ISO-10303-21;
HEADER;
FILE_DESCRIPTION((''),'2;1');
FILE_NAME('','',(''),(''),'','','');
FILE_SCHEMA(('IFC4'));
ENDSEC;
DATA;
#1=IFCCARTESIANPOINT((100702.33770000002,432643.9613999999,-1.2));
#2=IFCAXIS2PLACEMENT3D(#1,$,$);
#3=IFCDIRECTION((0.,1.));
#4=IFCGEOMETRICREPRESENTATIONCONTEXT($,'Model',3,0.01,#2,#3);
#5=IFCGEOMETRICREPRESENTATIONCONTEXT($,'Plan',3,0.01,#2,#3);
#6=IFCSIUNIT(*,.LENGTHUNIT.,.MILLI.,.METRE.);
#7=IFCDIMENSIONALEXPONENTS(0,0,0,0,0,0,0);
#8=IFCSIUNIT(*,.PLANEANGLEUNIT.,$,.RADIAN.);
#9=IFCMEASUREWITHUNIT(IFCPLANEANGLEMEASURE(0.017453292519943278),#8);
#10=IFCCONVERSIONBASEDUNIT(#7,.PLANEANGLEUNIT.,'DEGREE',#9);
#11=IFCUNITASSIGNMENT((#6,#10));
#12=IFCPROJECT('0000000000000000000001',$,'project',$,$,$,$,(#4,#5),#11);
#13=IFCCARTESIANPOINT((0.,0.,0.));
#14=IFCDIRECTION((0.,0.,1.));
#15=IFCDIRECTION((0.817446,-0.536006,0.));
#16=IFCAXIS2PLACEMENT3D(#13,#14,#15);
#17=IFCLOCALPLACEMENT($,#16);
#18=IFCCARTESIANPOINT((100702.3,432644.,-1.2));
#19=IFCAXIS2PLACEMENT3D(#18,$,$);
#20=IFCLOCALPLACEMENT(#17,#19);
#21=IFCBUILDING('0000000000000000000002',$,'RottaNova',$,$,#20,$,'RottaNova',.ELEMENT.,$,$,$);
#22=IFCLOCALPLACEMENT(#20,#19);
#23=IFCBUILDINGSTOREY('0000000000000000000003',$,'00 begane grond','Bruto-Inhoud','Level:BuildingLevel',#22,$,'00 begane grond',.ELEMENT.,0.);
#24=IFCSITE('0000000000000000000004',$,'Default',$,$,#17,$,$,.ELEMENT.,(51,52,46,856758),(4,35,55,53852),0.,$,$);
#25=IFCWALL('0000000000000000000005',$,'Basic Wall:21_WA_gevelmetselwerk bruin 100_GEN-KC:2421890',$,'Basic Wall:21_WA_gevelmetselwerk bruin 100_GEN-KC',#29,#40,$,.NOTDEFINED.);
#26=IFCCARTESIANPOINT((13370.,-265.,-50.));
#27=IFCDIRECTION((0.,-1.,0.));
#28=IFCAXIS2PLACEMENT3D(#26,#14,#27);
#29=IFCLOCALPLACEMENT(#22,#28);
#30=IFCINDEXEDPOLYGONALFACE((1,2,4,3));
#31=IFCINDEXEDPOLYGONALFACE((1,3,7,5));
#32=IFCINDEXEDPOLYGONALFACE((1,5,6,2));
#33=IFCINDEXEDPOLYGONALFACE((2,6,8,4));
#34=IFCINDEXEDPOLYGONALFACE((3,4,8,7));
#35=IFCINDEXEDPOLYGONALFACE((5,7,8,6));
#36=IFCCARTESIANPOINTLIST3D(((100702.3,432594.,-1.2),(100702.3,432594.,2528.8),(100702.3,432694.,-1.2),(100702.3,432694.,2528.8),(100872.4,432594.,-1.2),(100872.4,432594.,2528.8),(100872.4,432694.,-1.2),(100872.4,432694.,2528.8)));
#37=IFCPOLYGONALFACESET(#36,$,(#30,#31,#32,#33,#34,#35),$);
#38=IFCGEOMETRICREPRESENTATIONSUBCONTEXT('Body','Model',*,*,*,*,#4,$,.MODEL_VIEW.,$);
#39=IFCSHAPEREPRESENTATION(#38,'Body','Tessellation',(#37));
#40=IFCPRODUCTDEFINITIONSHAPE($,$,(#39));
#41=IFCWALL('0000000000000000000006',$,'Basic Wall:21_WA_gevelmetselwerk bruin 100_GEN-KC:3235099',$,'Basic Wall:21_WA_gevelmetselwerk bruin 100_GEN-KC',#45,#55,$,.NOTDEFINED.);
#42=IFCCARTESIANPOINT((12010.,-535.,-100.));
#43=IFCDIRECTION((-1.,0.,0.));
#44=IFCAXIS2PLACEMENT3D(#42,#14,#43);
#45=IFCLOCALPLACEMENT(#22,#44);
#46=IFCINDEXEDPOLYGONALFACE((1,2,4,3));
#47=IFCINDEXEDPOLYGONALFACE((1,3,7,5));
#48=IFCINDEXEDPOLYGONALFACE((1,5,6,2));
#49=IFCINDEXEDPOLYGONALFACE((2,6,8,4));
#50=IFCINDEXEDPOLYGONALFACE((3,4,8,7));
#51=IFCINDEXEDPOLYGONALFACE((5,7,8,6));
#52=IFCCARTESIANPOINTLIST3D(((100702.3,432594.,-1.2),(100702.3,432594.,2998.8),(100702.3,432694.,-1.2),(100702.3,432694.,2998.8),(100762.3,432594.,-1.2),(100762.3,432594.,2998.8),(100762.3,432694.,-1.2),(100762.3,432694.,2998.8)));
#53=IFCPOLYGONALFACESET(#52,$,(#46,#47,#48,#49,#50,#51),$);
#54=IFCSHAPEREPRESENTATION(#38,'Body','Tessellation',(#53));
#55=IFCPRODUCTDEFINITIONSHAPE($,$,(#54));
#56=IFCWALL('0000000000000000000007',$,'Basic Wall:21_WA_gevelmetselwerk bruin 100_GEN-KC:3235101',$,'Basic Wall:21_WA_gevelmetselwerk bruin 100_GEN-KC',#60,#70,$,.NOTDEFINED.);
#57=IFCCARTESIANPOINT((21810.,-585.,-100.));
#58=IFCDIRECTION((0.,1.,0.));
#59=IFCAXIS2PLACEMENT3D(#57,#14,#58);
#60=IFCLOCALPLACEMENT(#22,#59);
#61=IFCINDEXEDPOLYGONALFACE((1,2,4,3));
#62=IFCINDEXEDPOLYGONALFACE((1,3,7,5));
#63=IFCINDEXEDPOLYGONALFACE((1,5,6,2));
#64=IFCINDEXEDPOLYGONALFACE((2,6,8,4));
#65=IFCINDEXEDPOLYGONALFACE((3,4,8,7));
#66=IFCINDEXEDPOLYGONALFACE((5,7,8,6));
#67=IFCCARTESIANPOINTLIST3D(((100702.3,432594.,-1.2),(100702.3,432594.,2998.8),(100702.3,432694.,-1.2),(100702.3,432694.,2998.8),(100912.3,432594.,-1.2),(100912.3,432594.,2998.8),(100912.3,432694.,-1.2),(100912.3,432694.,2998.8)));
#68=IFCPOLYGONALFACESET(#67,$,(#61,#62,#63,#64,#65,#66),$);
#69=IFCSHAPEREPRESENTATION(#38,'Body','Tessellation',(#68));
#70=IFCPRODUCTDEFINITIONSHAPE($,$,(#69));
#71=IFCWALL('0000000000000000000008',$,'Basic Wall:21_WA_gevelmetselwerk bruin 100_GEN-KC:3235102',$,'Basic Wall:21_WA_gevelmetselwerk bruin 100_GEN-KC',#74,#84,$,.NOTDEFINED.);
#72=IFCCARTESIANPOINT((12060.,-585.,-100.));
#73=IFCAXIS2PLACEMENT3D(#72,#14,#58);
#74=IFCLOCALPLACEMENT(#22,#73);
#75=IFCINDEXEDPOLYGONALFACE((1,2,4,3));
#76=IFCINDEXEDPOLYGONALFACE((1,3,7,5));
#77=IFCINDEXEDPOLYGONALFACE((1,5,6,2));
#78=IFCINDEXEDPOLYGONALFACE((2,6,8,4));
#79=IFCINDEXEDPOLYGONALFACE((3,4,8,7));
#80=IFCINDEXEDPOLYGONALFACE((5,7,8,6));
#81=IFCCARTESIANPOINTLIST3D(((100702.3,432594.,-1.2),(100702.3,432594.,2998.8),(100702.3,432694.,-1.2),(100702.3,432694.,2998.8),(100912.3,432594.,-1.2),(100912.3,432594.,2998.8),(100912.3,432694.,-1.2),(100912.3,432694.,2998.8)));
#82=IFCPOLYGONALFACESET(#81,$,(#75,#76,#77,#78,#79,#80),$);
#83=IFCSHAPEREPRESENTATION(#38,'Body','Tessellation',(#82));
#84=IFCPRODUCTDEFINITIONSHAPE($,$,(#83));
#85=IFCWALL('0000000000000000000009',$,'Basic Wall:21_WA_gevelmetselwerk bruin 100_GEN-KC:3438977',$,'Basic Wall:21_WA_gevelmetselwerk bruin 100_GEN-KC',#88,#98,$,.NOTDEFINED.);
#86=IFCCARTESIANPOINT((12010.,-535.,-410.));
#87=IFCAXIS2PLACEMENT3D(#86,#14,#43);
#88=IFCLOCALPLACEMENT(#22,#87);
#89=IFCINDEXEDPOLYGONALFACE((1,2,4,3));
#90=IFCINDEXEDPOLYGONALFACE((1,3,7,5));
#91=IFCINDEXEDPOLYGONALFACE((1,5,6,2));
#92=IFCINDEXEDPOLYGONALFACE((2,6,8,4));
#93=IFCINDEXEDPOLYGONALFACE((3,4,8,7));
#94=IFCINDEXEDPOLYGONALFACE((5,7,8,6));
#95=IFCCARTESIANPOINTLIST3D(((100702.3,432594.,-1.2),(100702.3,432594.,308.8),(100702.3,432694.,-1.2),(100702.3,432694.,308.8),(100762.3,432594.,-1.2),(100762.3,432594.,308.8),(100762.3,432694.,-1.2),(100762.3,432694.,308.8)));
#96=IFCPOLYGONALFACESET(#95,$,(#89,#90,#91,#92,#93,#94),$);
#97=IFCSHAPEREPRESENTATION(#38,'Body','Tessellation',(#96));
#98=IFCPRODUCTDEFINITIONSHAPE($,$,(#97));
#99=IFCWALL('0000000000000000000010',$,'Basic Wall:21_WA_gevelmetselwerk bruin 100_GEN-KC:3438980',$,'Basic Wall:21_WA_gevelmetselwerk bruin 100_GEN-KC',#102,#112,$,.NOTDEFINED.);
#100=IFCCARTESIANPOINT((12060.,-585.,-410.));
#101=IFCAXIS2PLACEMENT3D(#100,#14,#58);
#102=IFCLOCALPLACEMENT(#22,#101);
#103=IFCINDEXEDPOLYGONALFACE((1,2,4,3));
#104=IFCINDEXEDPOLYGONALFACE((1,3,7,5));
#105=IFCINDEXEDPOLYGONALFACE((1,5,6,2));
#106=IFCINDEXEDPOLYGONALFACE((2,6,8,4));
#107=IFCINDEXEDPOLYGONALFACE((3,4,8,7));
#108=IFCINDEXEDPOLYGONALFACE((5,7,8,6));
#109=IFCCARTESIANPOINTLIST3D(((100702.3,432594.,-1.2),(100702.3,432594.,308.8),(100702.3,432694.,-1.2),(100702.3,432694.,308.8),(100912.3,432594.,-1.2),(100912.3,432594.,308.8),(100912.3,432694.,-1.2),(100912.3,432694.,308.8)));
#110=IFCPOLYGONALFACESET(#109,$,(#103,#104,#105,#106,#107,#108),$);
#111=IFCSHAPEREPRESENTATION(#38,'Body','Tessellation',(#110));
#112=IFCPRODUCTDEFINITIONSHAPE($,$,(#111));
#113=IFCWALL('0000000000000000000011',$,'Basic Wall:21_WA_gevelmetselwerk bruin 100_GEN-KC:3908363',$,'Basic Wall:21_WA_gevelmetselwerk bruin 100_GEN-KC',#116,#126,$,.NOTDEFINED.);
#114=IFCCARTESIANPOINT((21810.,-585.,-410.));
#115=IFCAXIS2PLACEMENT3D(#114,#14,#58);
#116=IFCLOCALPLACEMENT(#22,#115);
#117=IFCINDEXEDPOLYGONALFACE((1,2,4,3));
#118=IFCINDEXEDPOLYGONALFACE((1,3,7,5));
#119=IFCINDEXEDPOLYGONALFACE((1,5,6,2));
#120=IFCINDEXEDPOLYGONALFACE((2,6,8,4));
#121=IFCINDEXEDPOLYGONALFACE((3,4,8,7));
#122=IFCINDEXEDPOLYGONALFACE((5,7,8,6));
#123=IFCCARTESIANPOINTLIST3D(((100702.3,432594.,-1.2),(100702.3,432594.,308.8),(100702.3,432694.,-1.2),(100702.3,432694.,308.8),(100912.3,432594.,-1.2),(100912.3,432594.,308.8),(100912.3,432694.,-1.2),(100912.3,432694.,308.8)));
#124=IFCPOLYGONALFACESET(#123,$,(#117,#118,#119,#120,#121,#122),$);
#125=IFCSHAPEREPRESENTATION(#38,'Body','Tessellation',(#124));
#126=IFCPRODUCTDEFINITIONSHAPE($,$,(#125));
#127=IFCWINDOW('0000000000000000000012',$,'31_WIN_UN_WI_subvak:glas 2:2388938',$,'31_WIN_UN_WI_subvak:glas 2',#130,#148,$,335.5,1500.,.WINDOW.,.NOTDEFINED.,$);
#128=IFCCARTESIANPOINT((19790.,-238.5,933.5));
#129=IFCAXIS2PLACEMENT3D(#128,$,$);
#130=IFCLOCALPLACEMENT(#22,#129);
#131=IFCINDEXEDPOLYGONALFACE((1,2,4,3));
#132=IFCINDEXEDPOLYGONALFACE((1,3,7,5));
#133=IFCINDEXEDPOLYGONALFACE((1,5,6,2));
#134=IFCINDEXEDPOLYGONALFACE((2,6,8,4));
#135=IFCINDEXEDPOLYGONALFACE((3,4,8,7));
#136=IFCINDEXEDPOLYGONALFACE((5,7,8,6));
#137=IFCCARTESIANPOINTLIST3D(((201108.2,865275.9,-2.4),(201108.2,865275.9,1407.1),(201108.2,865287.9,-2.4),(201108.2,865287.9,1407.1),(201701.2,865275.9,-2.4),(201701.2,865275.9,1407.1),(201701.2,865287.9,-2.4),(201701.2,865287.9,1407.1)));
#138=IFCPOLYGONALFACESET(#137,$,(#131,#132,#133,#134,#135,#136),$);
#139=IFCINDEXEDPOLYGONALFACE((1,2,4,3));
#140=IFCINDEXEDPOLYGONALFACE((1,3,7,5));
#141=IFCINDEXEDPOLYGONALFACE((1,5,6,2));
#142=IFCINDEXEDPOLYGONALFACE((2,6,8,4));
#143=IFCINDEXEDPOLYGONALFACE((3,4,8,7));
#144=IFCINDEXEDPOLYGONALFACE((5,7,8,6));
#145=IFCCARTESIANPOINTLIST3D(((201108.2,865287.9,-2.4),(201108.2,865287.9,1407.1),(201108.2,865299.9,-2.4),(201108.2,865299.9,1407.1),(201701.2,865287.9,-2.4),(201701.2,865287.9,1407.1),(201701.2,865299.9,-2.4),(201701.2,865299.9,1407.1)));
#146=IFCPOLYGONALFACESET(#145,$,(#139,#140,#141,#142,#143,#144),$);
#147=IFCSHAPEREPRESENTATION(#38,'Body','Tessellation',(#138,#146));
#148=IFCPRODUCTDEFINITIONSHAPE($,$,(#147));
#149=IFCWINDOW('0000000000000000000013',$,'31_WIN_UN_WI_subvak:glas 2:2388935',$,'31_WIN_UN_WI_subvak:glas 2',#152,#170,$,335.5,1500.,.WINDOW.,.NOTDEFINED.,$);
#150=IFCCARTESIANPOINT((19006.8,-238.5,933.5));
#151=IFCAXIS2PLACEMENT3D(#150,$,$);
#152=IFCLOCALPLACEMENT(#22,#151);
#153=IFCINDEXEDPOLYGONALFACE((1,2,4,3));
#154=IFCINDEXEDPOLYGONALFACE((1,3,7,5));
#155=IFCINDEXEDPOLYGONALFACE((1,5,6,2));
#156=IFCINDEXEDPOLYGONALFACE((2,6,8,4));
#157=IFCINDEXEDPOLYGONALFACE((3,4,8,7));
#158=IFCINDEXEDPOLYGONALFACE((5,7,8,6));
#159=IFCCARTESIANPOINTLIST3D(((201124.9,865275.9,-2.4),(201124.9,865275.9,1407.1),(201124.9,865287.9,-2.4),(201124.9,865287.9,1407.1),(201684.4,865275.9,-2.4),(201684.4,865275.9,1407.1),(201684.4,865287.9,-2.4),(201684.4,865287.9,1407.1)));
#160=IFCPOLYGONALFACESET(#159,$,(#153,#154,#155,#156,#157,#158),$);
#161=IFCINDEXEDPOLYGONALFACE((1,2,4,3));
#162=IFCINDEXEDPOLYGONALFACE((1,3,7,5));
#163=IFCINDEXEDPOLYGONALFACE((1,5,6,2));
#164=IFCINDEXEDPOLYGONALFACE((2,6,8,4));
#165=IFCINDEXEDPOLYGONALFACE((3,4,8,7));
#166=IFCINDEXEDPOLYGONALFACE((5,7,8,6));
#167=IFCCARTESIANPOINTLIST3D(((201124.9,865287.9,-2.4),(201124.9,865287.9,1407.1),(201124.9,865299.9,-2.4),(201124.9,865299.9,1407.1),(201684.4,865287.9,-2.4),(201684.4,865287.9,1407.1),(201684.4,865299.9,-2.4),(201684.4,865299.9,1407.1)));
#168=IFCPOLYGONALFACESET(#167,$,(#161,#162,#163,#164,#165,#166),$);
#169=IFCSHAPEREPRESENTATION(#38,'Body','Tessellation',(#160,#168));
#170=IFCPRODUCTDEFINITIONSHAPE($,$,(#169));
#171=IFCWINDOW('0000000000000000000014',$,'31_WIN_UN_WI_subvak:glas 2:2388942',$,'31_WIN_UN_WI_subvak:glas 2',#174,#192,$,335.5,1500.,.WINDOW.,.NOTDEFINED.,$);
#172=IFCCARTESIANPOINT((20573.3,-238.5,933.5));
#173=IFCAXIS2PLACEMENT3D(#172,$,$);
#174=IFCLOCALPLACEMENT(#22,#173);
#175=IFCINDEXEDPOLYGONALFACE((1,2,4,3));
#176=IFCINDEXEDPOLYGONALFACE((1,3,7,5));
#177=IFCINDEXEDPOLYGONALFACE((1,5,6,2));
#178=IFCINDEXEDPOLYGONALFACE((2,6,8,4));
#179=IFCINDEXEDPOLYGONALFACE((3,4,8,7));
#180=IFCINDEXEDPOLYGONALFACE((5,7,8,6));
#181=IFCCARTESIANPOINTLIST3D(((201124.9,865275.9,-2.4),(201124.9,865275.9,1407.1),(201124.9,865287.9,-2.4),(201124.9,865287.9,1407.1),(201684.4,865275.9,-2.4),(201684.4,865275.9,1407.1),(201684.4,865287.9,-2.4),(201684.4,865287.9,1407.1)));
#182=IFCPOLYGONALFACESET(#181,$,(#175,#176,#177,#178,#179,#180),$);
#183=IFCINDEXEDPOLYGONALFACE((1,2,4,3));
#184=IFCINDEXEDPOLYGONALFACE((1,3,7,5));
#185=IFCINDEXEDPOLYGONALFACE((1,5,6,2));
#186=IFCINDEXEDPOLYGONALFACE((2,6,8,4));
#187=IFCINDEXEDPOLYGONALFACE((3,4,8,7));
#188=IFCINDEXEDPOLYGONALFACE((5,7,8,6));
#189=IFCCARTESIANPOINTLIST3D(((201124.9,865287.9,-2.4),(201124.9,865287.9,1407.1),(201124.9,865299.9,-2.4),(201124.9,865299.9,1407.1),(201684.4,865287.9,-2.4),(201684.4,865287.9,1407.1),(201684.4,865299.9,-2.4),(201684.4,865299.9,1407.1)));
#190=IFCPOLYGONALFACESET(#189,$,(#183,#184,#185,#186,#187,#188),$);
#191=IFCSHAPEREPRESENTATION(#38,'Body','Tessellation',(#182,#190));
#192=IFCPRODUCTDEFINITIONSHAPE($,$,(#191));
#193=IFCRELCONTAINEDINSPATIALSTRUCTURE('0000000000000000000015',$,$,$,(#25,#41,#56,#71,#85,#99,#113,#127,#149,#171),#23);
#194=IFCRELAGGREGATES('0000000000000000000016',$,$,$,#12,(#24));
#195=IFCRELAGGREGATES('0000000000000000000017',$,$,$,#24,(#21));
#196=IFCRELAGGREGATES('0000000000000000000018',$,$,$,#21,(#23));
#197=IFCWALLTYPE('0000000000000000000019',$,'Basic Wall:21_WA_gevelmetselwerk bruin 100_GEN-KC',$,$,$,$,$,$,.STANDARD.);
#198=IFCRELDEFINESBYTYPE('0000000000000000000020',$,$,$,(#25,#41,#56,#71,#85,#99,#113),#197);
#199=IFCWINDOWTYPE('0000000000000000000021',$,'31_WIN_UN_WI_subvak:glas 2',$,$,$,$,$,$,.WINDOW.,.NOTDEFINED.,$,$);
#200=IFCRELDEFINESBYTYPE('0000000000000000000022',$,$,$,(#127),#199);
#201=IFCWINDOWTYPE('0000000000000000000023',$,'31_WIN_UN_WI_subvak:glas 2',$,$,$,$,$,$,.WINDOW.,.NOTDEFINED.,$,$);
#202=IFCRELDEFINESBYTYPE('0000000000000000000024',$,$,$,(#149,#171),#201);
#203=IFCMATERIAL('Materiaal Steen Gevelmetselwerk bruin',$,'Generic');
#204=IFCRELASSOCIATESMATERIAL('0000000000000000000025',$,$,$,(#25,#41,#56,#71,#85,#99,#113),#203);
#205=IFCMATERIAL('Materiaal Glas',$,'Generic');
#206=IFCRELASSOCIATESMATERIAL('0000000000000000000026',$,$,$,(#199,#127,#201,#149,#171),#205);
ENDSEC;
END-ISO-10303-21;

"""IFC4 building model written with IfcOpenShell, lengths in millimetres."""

from ifc_helpers import new_model, entity, si_unit, converted_unit, direction, frame, place, context, subcontext, project, spatial, indexed_curve, outline, extrude, source, transform, mapped, material, type_object, type_shapes, element, save


model = new_model("IFC4")

# Units and contexts
model_context = context("Model", 3, precision=0.01, world=frame((100702.33770000002, 432643.9613999999, -1.2)), true_north=direction((0.0, 1.0)))
plan_context = context("Plan", 3, precision=0.01, world=frame((100702.33770000002, 432643.9613999999, -1.2)), true_north=direction((0.0, 1.0)))
body_context = subcontext(model_context, "Body", "Model", "MODEL_VIEW")
ifc_project = project(units=[si_unit("LENGTHUNIT", "METRE", prefix="MILLI"), converted_unit("PLANEANGLEUNIT", "DEGREE", entity("IfcPlaneAngleMeasure", 0.017453292519943278), si_unit("PLANEANGLEUNIT", "RADIAN"), dimensions=[0, 0, 0, 0, 0, 0, 0])], contexts=[model_context, plan_context])

# Site, building, storey
site_placement = place(None, frame((0.0, 0.0, 0.0), z_axis=(0.0, 0.0, 1.0), x_axis=(0.817446, -0.536006, 0.0)))
site = spatial("IfcSite", under=ifc_project, at=site_placement, Name="Default", CompositionType="ELEMENT", RefLatitude=(51, 52, 46, 856758), RefLongitude=(4, 35, 55, 53852), RefElevation=0.0)
building_placement = place(site_placement, frame((100702.3, 432644.0, -1.2)))
building = spatial("IfcBuilding", under=site, at=building_placement, Name="RottaNova", LongName="RottaNova", CompositionType="ELEMENT")
storey_placement = place(building_placement, frame((100702.3, 432644.0, -1.2)))
storey = spatial("IfcBuildingStorey", under=building, at=storey_placement, Name="00 begane grond", Description="Bruto-Inhoud", ObjectType="Level:BuildingLevel", LongName="00 begane grond", CompositionType="ELEMENT", Elevation=0.0)

# Walls
ifc_material_1 = material(Name="Materiaal Steen Gevelmetselwerk bruin", Category="Generic")
wall_type_1 = type_object("IfcWallType", Name="Basic Wall:21_WA_gevelmetselwerk bruin 100_GEN-KC", PredefinedType="STANDARD")
wall_1_placement = place(storey_placement, frame((13370.0, -265.0, -50.0), z_axis=(0.0, 0.0, 1.0), x_axis=(0.0, -1.0, 0.0)))
element("IfcWall", 1, at=wall_1_placement, inside=storey, type_object=wall_type_1, material=ifc_material_1, Name="Basic Wall:21_WA_gevelmetselwerk bruin 100_GEN-KC:2421890", ObjectType="Basic Wall:21_WA_gevelmetselwerk bruin 100_GEN-KC", PredefinedType="NOTDEFINED", context=body_context, shape_type="SweptSolid", body=[
    extrude(outline(indexed_curve([(170.0, 50.0), (0.0, 50.0), (0.0, -50.0), (170.0, -50.0), (170.0, 50.0)], self_intersect=False)), frame((100702.3, 432644.0, -1.2)), (0.0, 0.0, 1.0), 2530.0),
])
wall_2_placement = place(storey_placement, frame((12010.0, -535.0, -100.0), z_axis=(0.0, 0.0, 1.0), x_axis=(-1.0, 0.0, 0.0)))
element("IfcWall", 2, at=wall_2_placement, inside=storey, type_object=wall_type_1, material=ifc_material_1, Name="Basic Wall:21_WA_gevelmetselwerk bruin 100_GEN-KC:3235099", ObjectType="Basic Wall:21_WA_gevelmetselwerk bruin 100_GEN-KC", PredefinedType="NOTDEFINED", context=body_context, shape_type="SweptSolid", body=[
    extrude(outline(indexed_curve([(60.0, 50.0), (0.0, 50.0), (0.0, -50.0), (60.0, -50.0), (60.0, 50.0)], self_intersect=False)), frame((100702.3, 432644.0, -1.2)), (0.0, 0.0, 1.0), 3000.0),
])
wall_3_placement = place(storey_placement, frame((21810.0, -585.0, -100.0), z_axis=(0.0, 0.0, 1.0), x_axis=(0.0, 1.0, 0.0)))
element("IfcWall", 3, at=wall_3_placement, inside=storey, type_object=wall_type_1, material=ifc_material_1, Name="Basic Wall:21_WA_gevelmetselwerk bruin 100_GEN-KC:3235101", ObjectType="Basic Wall:21_WA_gevelmetselwerk bruin 100_GEN-KC", PredefinedType="NOTDEFINED", context=body_context, shape_type="SweptSolid", body=[
    extrude(outline(indexed_curve([(210.0, 50.0), (0.0, 50.0), (0.0, -50.0), (210.0, -50.0), (210.0, 50.0)], self_intersect=False)), frame((100702.3, 432644.0, -1.2)), (0.0, 0.0, 1.0), 3000.0),
])
wall_4_placement = place(storey_placement, frame((12060.0, -585.0, -100.0), z_axis=(0.0, 0.0, 1.0), x_axis=(0.0, 1.0, 0.0)))
element("IfcWall", 4, at=wall_4_placement, inside=storey, type_object=wall_type_1, material=ifc_material_1, Name="Basic Wall:21_WA_gevelmetselwerk bruin 100_GEN-KC:3235102", ObjectType="Basic Wall:21_WA_gevelmetselwerk bruin 100_GEN-KC", PredefinedType="NOTDEFINED", context=body_context, shape_type="SweptSolid", body=[
    extrude(outline(indexed_curve([(210.0, 50.0), (0.0, 50.0), (0.0, -50.0), (210.0, -50.0), (210.0, 50.0)], self_intersect=False)), frame((100702.3, 432644.0, -1.2)), (0.0, 0.0, 1.0), 3000.0),
])
wall_5_placement = place(storey_placement, frame((12010.0, -535.0, -410.0), z_axis=(0.0, 0.0, 1.0), x_axis=(-1.0, 0.0, 0.0)))
element("IfcWall", 5, at=wall_5_placement, inside=storey, type_object=wall_type_1, material=ifc_material_1, Name="Basic Wall:21_WA_gevelmetselwerk bruin 100_GEN-KC:3438977", ObjectType="Basic Wall:21_WA_gevelmetselwerk bruin 100_GEN-KC", PredefinedType="NOTDEFINED", context=body_context, shape_type="SweptSolid", body=[
    extrude(outline(indexed_curve([(60.0, 50.0), (0.0, 50.0), (0.0, -50.0), (60.0, -50.0), (60.0, 50.0)], self_intersect=False)), frame((100702.3, 432644.0, -1.2)), (0.0, 0.0, 1.0), 310.0),
])
wall_6_placement = place(storey_placement, frame((12060.0, -585.0, -410.0), z_axis=(0.0, 0.0, 1.0), x_axis=(0.0, 1.0, 0.0)))
element("IfcWall", 6, at=wall_6_placement, inside=storey, type_object=wall_type_1, material=ifc_material_1, Name="Basic Wall:21_WA_gevelmetselwerk bruin 100_GEN-KC:3438980", ObjectType="Basic Wall:21_WA_gevelmetselwerk bruin 100_GEN-KC", PredefinedType="NOTDEFINED", context=body_context, shape_type="SweptSolid", body=[
    extrude(outline(indexed_curve([(210.0, 50.0), (0.0, 50.0), (0.0, -50.0), (210.0, -50.0), (210.0, 50.0)], self_intersect=False)), frame((100702.3, 432644.0, -1.2)), (0.0, 0.0, 1.0), 310.0),
])
wall_7_placement = place(storey_placement, frame((21810.0, -585.0, -410.0), z_axis=(0.0, 0.0, 1.0), x_axis=(0.0, 1.0, 0.0)))
element("IfcWall", 7, at=wall_7_placement, inside=storey, type_object=wall_type_1, material=ifc_material_1, Name="Basic Wall:21_WA_gevelmetselwerk bruin 100_GEN-KC:3908363", ObjectType="Basic Wall:21_WA_gevelmetselwerk bruin 100_GEN-KC", PredefinedType="NOTDEFINED", context=body_context, shape_type="SweptSolid", body=[
    extrude(outline(indexed_curve([(210.0, 50.0), (0.0, 50.0), (0.0, -50.0), (210.0, -50.0), (210.0, 50.0)], self_intersect=False)), frame((100702.3, 432644.0, -1.2)), (0.0, 0.0, 1.0), 310.0),
])

# Windows
ifc_material_2 = material(Name="Materiaal Glas", Category="Generic")
window_type_1 = type_object("IfcWindowType", Name="31_WIN_UN_WI_subvak:glas 2", PartitioningType="NOTDEFINED", PredefinedType="WINDOW", material=ifc_material_2)
shared_shape_1 = source(frame((100702.3, 432644.0, -1.2)), body_context, "Body", "SweptSolid", [
    extrude(outline(indexed_curve([(-296.5, -6.0), (296.5, -6.0), (296.5, 6.0), (-296.5, 6.0), (-296.5, -6.0)], self_intersect=False)), frame((0.0, -6.0, 0.0)), (0.0, 0.0, 1.0), 1409.5),
    extrude(outline(indexed_curve([(-296.5, -6.0), (296.5, -6.0), (296.5, 6.0), (-296.5, 6.0), (-296.5, -6.0)], self_intersect=False)), frame((0.0, 6.0, 0.0)), (0.0, 0.0, 1.0), 1409.5),
])
type_shapes(window_type_1, [shared_shape_1])
window_1_placement = place(storey_placement, frame((19790.0, -238.5, 933.5)))
element("IfcWindow", 8, at=window_1_placement, inside=storey, type_object=window_type_1, material=ifc_material_2, Name="31_WIN_UN_WI_subvak:glas 2:2388938", ObjectType="31_WIN_UN_WI_subvak:glas 2", OverallHeight=335.5, OverallWidth=1500.0, PartitioningType="NOTDEFINED", PredefinedType="WINDOW", context=body_context, shape_type="MappedRepresentation", body=[
    mapped(shared_shape_1, transform((100702.3, 432644.0, -1.2), scale=1.0)),
])
window_type_2 = type_object("IfcWindowType", Name="31_WIN_UN_WI_subvak:glas 2", PartitioningType="NOTDEFINED", PredefinedType="WINDOW", material=ifc_material_2)
shared_shape_2 = source(frame((100702.3, 432644.0, -1.2)), body_context, "Body", "SweptSolid", [
    extrude(outline(indexed_curve([(-279.8, -6.0), (279.8, -6.0), (279.8, 6.0), (-279.8, 6.0), (-279.8, -6.0)], self_intersect=False)), frame((0.0, -6.0, 0.0)), (0.0, 0.0, 1.0), 1409.5),
    extrude(outline(indexed_curve([(-279.8, -6.0), (279.8, -6.0), (279.8, 6.0), (-279.8, 6.0), (-279.8, -6.0)], self_intersect=False)), frame((0.0, 6.0, 0.0)), (0.0, 0.0, 1.0), 1409.5),
])
type_shapes(window_type_2, [shared_shape_2])
for number, where, name in (
    (9, (19006.8, -238.5, 933.5), "31_WIN_UN_WI_subvak:glas 2:2388935"),
    (10, (20573.3, -238.5, 933.5), "31_WIN_UN_WI_subvak:glas 2:2388942"),
):
    element("IfcWindow", number, at=place(storey_placement, frame(where)), inside=storey, type_object=window_type_2, material=ifc_material_2, Name=name, ObjectType="31_WIN_UN_WI_subvak:glas 2", OverallHeight=335.5, OverallWidth=1500.0, PartitioningType="NOTDEFINED", PredefinedType="WINDOW", context=body_context, shape_type="MappedRepresentation", body=[
        mapped(shared_shape_2, transform((100702.3, 432644.0, -1.2), scale=1.0)),
    ])

save(model, "model.ifc")
